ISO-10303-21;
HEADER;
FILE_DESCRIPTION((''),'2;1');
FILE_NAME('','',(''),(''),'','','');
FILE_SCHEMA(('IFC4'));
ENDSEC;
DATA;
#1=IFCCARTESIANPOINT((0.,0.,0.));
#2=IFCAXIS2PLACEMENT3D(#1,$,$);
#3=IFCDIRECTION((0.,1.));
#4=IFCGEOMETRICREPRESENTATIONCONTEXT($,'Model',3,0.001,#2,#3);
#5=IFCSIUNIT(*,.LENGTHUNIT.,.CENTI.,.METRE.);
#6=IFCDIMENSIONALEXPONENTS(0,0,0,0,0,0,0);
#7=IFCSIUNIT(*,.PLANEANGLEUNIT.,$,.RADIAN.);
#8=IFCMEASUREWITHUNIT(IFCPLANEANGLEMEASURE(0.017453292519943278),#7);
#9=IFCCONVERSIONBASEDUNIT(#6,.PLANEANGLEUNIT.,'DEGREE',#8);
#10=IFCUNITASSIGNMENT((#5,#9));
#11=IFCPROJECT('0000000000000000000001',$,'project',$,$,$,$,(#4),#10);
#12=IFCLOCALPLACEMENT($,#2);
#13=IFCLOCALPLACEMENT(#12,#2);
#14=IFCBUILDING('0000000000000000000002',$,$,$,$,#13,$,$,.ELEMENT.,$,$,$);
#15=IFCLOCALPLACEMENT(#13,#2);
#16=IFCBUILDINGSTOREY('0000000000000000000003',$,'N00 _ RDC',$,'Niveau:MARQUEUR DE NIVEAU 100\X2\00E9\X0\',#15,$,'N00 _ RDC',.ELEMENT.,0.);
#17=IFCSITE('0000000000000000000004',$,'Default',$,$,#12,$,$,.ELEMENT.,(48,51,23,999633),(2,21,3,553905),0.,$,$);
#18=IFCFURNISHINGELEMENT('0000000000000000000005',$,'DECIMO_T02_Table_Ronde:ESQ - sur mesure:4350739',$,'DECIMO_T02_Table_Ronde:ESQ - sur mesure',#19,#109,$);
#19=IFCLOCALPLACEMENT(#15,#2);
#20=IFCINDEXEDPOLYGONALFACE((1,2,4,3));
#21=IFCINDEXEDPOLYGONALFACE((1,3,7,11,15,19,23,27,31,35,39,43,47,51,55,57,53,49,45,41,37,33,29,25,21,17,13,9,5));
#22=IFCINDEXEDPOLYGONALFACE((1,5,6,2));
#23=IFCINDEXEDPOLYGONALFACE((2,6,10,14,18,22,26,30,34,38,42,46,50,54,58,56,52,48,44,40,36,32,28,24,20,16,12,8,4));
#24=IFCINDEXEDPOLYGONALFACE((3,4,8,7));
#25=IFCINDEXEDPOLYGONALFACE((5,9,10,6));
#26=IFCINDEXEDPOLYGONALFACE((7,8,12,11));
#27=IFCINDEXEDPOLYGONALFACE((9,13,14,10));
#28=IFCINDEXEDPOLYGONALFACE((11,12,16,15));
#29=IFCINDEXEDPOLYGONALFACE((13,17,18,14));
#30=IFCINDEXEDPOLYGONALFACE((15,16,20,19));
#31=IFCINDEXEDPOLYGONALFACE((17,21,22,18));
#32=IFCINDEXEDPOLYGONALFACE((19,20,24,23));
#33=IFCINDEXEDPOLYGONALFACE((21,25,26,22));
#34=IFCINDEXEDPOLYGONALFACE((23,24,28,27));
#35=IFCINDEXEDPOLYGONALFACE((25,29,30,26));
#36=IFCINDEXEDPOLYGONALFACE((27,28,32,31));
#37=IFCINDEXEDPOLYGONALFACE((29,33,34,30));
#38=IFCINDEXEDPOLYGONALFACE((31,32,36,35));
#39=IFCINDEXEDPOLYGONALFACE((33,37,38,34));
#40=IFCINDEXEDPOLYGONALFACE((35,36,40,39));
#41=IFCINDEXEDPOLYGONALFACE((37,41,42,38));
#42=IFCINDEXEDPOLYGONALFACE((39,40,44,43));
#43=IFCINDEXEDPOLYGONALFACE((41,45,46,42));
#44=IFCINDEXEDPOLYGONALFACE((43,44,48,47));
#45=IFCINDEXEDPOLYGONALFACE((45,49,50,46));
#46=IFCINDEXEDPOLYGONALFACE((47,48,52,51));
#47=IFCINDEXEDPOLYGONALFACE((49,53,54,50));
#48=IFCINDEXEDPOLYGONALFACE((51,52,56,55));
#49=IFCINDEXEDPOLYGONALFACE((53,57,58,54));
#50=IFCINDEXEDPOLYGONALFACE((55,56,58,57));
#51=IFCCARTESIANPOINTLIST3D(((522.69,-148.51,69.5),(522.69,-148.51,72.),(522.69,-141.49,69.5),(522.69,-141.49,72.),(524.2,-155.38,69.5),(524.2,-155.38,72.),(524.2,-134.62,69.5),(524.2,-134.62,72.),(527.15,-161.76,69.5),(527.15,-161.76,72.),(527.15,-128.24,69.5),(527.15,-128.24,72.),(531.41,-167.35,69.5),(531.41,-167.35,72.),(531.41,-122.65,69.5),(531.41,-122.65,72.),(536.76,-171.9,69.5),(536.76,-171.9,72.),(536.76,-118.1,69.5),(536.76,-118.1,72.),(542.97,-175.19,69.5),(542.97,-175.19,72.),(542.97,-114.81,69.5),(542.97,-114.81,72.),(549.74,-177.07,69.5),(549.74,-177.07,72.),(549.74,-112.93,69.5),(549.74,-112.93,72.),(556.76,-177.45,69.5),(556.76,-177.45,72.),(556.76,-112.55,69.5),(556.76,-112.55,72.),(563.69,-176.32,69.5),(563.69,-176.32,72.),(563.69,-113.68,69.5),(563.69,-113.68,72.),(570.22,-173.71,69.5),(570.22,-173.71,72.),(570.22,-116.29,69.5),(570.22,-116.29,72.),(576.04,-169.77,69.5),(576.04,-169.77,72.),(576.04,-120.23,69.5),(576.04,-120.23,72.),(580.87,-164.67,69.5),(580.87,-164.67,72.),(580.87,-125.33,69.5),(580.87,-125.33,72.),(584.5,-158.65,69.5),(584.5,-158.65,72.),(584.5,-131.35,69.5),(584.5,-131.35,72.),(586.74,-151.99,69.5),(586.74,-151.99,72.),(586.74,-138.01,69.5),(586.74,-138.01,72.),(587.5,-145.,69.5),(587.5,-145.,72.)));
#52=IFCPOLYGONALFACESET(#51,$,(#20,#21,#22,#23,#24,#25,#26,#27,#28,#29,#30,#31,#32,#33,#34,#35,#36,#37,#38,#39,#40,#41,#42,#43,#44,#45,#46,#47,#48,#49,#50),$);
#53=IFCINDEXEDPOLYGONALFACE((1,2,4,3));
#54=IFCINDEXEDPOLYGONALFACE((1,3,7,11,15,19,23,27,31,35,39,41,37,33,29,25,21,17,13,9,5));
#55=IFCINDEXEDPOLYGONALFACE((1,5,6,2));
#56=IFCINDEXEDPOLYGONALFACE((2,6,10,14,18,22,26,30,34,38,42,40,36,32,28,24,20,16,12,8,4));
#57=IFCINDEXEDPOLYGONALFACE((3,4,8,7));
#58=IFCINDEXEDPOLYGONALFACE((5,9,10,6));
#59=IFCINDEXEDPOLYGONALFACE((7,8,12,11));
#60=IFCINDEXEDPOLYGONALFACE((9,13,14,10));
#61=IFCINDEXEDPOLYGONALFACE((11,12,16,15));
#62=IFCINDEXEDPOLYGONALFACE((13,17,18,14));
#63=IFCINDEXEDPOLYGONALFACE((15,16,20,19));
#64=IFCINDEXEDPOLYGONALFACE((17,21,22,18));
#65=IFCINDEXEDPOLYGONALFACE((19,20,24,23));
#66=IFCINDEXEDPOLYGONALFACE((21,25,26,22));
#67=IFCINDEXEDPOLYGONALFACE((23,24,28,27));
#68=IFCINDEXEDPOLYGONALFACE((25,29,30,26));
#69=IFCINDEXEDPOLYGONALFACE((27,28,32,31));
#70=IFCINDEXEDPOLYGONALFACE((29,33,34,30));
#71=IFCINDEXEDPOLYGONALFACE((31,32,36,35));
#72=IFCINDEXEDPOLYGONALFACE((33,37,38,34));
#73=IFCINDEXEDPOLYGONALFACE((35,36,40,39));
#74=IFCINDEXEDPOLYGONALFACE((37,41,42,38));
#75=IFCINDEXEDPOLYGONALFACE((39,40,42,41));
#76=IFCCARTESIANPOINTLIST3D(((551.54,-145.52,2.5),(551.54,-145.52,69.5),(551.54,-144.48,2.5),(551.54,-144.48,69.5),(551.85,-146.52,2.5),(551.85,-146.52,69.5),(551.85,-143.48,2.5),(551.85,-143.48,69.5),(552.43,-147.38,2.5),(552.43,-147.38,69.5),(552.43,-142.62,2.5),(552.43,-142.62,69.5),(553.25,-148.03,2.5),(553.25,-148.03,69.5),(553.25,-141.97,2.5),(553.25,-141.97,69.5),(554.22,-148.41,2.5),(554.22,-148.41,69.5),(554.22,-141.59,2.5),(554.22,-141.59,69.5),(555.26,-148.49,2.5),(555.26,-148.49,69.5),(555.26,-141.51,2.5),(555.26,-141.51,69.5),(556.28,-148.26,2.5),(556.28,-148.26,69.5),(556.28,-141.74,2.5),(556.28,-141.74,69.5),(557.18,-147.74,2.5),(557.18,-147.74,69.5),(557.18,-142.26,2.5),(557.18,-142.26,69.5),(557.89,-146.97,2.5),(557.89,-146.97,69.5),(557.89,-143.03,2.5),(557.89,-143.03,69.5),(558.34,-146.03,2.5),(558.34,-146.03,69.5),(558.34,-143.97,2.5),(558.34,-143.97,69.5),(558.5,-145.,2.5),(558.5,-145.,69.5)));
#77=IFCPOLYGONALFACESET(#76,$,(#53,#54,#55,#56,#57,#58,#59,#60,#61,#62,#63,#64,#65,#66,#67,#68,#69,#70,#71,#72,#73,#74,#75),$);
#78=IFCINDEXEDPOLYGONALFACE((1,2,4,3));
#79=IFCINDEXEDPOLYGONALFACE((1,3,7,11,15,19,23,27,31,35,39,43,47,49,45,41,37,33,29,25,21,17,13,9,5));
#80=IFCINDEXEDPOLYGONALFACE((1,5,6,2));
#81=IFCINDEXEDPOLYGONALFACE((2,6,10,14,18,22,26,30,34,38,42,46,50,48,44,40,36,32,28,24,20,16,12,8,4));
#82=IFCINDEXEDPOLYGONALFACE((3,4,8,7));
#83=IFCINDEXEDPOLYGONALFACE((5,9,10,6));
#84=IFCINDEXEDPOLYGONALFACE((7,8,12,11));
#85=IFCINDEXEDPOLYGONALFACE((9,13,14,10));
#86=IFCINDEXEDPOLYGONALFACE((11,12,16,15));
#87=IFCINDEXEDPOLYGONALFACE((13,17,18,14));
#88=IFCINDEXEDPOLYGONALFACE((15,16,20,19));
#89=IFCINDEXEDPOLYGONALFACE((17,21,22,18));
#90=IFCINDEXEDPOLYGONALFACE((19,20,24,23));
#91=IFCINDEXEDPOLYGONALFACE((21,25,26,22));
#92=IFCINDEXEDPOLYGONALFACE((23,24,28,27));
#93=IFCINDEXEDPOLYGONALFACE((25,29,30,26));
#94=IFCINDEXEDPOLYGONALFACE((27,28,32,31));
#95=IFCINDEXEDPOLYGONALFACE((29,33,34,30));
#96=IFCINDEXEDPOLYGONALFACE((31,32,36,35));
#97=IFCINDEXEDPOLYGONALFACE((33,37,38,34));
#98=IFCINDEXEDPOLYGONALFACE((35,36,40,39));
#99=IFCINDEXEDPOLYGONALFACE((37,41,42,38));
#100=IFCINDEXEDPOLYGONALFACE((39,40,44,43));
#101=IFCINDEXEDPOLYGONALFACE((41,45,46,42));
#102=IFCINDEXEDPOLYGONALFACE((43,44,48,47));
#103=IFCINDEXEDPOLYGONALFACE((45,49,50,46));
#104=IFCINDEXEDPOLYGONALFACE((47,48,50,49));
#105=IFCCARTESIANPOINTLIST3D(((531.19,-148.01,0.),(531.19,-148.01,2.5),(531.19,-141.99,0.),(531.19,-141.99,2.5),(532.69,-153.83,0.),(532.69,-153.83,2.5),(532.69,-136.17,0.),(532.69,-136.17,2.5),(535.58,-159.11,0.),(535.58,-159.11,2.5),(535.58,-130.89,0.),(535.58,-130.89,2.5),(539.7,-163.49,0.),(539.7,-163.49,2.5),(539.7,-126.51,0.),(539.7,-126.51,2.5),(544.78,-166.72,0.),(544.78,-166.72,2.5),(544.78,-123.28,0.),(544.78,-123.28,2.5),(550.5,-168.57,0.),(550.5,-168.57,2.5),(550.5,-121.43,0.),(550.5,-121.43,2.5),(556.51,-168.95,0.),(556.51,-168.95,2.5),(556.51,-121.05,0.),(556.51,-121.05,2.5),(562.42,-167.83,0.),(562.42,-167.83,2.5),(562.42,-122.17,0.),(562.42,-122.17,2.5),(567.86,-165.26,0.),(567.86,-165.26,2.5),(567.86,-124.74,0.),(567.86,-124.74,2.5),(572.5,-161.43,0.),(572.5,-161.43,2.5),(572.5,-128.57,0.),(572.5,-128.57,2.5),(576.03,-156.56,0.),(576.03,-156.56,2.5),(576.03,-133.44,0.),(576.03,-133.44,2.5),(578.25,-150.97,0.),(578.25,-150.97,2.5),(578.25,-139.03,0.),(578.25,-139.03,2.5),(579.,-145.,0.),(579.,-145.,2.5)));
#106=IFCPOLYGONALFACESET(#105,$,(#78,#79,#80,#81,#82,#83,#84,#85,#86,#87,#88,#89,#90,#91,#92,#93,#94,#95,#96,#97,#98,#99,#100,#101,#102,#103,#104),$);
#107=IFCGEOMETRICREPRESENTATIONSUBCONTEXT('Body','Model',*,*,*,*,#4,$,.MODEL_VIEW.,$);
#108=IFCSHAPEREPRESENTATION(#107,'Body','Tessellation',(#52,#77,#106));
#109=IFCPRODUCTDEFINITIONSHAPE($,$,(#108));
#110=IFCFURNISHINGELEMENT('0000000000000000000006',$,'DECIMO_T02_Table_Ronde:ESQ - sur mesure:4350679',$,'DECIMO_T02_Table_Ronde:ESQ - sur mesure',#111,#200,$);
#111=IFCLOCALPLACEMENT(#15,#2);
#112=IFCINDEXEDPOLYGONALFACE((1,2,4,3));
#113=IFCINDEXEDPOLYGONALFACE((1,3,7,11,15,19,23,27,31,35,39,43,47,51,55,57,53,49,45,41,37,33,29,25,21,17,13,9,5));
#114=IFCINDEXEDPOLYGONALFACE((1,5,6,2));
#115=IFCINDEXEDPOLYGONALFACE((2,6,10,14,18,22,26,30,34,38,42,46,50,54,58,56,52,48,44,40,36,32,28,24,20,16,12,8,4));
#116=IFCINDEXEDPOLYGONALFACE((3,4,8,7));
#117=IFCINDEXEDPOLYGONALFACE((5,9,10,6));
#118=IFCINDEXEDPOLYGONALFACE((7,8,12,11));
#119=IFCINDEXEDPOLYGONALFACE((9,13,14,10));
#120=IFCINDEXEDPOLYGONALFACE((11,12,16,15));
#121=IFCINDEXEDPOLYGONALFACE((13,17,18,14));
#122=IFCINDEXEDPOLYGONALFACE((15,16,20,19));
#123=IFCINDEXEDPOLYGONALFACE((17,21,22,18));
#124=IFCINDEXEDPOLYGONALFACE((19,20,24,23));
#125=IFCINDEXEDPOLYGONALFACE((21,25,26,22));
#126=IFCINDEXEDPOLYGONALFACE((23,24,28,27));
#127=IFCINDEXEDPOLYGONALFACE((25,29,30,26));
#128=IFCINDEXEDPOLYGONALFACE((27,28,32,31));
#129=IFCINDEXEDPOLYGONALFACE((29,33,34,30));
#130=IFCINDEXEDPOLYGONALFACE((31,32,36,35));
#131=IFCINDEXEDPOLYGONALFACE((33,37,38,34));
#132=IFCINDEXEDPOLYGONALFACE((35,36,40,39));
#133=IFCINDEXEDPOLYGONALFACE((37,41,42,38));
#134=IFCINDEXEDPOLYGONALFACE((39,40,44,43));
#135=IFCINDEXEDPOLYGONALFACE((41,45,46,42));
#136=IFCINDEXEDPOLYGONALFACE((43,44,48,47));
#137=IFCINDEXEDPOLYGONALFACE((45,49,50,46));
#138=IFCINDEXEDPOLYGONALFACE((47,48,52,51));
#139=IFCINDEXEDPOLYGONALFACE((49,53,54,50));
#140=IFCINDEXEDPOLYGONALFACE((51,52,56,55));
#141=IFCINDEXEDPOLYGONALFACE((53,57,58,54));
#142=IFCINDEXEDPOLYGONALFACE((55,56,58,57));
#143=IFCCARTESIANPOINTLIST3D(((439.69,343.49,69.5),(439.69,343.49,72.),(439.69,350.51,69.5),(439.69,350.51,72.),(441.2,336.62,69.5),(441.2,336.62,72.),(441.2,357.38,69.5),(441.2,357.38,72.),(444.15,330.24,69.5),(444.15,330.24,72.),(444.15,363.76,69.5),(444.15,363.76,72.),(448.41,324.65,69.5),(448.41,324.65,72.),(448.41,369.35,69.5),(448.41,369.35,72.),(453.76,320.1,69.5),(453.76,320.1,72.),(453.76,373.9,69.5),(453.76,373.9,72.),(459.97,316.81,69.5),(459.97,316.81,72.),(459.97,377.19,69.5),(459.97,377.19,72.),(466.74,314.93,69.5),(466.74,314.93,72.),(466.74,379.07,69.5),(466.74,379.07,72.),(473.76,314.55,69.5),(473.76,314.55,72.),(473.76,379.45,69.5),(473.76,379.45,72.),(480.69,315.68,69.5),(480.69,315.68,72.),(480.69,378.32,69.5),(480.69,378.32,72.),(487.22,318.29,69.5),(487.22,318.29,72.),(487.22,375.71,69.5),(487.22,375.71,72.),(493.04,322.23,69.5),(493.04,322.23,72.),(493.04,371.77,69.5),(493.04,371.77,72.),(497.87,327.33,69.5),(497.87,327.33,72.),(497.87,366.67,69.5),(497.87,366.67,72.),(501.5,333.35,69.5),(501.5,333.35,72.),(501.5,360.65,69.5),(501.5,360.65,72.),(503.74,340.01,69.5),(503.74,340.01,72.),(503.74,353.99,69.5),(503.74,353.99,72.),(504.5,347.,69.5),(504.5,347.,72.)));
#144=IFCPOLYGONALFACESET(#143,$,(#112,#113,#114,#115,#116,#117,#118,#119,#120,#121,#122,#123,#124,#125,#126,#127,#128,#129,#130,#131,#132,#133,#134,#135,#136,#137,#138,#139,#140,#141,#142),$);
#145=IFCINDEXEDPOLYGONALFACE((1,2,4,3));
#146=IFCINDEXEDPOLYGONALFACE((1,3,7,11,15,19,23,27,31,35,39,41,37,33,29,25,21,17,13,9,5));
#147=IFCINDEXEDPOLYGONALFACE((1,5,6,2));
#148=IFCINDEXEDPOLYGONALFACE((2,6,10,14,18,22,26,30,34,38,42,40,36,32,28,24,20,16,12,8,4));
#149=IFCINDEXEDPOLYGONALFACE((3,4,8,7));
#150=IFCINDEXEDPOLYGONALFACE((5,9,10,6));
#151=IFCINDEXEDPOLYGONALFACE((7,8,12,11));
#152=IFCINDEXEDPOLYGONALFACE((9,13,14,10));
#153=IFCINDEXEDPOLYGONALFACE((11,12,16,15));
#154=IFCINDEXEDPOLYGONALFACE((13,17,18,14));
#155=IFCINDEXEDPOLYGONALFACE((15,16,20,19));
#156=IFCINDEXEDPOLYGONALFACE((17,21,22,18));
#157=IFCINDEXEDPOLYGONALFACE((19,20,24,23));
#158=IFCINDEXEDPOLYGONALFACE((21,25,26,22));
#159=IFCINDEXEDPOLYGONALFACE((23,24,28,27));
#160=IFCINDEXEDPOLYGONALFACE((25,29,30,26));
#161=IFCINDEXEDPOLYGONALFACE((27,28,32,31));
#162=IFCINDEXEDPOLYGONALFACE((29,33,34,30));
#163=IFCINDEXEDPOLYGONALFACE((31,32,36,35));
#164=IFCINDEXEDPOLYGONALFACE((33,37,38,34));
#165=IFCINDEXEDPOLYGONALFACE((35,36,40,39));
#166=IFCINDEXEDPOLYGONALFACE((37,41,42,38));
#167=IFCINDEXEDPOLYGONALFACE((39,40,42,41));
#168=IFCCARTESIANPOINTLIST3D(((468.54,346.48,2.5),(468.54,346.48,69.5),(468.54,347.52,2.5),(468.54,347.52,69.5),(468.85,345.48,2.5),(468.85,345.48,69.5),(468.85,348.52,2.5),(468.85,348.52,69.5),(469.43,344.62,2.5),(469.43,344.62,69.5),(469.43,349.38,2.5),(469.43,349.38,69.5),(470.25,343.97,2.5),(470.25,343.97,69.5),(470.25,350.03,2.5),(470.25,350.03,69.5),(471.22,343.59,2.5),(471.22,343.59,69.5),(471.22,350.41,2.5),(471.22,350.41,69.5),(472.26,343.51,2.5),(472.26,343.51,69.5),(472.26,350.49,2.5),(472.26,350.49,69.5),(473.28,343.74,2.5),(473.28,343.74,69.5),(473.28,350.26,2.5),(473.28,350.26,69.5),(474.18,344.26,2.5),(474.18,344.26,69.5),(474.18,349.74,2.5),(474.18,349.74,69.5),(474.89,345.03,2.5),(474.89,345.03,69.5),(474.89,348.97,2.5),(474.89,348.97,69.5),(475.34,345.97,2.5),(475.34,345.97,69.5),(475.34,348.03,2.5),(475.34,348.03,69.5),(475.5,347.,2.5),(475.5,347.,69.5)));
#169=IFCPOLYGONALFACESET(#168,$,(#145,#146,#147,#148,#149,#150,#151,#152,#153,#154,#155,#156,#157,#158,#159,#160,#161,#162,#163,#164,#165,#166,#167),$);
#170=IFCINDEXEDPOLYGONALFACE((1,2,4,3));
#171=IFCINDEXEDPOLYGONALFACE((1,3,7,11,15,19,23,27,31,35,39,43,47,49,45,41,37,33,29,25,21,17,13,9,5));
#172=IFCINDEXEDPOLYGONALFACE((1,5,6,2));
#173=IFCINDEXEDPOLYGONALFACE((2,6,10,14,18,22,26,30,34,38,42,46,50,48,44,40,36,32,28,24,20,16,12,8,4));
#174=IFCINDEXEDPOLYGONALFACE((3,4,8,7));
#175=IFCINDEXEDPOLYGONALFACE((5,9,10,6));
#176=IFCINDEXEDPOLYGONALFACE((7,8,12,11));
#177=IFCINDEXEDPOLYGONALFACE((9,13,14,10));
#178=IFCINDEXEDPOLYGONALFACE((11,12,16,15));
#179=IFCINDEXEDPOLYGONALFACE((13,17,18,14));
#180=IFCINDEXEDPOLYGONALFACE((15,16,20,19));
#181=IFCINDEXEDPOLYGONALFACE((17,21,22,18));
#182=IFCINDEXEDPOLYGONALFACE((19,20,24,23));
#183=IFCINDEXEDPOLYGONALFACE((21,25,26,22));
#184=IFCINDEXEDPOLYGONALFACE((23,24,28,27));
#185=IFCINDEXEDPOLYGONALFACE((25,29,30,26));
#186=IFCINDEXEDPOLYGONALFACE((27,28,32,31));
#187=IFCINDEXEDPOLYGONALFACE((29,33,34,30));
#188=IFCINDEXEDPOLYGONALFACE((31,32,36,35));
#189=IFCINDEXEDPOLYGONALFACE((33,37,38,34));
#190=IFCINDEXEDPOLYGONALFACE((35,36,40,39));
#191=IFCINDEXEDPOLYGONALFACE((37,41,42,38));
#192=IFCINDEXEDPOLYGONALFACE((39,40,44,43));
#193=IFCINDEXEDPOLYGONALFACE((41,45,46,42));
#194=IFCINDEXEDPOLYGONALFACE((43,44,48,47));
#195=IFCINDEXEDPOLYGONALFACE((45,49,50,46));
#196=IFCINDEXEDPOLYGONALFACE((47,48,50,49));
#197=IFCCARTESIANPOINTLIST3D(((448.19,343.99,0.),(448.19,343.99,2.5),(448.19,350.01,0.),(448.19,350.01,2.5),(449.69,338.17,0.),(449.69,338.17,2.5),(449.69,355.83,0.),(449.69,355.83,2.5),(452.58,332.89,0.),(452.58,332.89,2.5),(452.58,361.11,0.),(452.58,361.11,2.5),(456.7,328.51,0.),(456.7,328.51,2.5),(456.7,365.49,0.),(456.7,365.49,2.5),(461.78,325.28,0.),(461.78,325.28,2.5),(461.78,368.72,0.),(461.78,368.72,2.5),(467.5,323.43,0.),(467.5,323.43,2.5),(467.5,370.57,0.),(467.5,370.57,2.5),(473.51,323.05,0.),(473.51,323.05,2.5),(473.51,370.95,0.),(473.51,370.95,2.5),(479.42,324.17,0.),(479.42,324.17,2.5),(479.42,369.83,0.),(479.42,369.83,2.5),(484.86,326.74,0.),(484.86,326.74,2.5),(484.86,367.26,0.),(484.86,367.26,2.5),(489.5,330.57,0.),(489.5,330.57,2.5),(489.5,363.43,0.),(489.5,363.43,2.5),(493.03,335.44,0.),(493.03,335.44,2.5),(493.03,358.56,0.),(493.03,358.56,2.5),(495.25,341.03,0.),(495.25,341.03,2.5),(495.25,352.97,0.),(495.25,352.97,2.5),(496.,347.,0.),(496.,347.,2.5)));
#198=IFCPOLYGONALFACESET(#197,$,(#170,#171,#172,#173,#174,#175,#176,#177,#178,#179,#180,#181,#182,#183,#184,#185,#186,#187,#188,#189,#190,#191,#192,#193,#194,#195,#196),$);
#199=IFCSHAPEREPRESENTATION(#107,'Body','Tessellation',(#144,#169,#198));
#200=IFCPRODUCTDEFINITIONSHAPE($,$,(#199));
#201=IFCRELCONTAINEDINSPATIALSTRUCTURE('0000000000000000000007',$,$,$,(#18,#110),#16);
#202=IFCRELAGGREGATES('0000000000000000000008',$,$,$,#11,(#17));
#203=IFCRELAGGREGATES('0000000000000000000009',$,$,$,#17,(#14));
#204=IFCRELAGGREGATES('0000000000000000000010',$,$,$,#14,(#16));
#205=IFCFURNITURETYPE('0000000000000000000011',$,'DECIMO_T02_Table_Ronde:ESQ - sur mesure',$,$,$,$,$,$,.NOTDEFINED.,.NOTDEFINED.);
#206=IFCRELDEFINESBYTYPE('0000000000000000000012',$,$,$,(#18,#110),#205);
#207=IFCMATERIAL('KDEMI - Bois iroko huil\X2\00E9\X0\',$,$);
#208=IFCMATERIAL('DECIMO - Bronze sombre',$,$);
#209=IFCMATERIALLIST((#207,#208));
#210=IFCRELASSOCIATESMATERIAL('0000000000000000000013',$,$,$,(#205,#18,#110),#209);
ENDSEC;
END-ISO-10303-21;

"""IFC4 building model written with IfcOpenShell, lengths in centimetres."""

from ifc_helpers import new_model, entity, si_unit, converted_unit, direction, frame, frame_2d, origin, place, context, subcontext, project, spatial, circle, extrude, source, transform, mapped, material, material_list, type_object, type_shapes, element, save


model = new_model("IFC4")

# Units and contexts
model_context = context("Model", 3, precision=0.001, world=origin(), true_north=direction((0.0, 1.0)))
body_context = subcontext(model_context, "Body", "Model", "MODEL_VIEW")
ifc_project = project(units=[si_unit("LENGTHUNIT", "METRE", prefix="CENTI"), converted_unit("PLANEANGLEUNIT", "DEGREE", entity("IfcPlaneAngleMeasure", 0.017453292519943278), si_unit("PLANEANGLEUNIT", "RADIAN"), dimensions=[0, 0, 0, 0, 0, 0, 0])], contexts=[model_context])

# Site, building, storey
site_placement = place(None, origin())
site = spatial("IfcSite", under=ifc_project, at=site_placement, Name="Default", CompositionType="ELEMENT", RefLatitude=(48, 51, 23, 999633), RefLongitude=(2, 21, 3, 553905), RefElevation=0.0)
building_placement = place(site_placement, origin())
building = spatial("IfcBuilding", under=site, at=building_placement, CompositionType="ELEMENT")
storey_placement = place(building_placement, origin())
storey = spatial("IfcBuildingStorey", under=building, at=storey_placement, Name="N00 _ RDC", ObjectType="Niveau:MARQUEUR DE NIVEAU 100é", LongName="N00 _ RDC", CompositionType="ELEMENT", Elevation=0.0)

# Furnishing elements
ifc_material_1 = material(Name="KDEMI - Bois iroko huilé")
ifc_material_2 = material(Name="DECIMO - Bronze sombre")
ifc_material_list_1 = material_list([ifc_material_1, ifc_material_2])
furniture_type_1 = type_object("IfcFurnitureType", Name="DECIMO_T02_Table_Ronde:ESQ - sur mesure", AssemblyPlace="NOTDEFINED", material=ifc_material_list_1)
shared_shape_1 = source(origin(), body_context, "Body", "SweptSolid", [
    extrude(circle(Radius=32.5, at=frame_2d((0.0, 0.0), x_axis=(1.0, 0.0))), frame((0.0, 0.0, 69.5)), (0.0, 0.0, 1.0), 2.5),
    extrude(circle(Radius=3.5, at=frame_2d((0.0, 0.0), x_axis=(1.0, 0.0))), frame((0.0, 0.0, 2.5)), (0.0, 0.0, 1.0), 67.0),
    extrude(circle(Radius=24.0, at=frame_2d((0.0, 0.0), x_axis=(1.0, 0.0))), origin(), (0.0, 0.0, 1.0), 2.5),
])
type_shapes(furniture_type_1, [shared_shape_1])
for number, where, z_axis, x_axis, name in (
    (1, (555.0, -145.0, 0.0), (0.0, 0.0, 1.0), (1.0, 0.0, 0.0), "DECIMO_T02_Table_Ronde:ESQ - sur mesure:4350739"),
    (2, (472.0, 347.0, 0.0), (0.0, 0.0, 1.0), (1.0, 0.0, 0.0), "DECIMO_T02_Table_Ronde:ESQ - sur mesure:4350679"),
):
    element("IfcFurnishingElement", number, at=place(storey_placement, frame(where, z_axis=z_axis, x_axis=x_axis)), inside=storey, type_object=furniture_type_1, material=ifc_material_list_1, Name=name, ObjectType="DECIMO_T02_Table_Ronde:ESQ - sur mesure", context=body_context, shape_type="MappedRepresentation", body=[
        mapped(shared_shape_1, transform((0.0, 0.0, 0.0), scale=1.0)),
    ])

save(model, "model.ifc")
